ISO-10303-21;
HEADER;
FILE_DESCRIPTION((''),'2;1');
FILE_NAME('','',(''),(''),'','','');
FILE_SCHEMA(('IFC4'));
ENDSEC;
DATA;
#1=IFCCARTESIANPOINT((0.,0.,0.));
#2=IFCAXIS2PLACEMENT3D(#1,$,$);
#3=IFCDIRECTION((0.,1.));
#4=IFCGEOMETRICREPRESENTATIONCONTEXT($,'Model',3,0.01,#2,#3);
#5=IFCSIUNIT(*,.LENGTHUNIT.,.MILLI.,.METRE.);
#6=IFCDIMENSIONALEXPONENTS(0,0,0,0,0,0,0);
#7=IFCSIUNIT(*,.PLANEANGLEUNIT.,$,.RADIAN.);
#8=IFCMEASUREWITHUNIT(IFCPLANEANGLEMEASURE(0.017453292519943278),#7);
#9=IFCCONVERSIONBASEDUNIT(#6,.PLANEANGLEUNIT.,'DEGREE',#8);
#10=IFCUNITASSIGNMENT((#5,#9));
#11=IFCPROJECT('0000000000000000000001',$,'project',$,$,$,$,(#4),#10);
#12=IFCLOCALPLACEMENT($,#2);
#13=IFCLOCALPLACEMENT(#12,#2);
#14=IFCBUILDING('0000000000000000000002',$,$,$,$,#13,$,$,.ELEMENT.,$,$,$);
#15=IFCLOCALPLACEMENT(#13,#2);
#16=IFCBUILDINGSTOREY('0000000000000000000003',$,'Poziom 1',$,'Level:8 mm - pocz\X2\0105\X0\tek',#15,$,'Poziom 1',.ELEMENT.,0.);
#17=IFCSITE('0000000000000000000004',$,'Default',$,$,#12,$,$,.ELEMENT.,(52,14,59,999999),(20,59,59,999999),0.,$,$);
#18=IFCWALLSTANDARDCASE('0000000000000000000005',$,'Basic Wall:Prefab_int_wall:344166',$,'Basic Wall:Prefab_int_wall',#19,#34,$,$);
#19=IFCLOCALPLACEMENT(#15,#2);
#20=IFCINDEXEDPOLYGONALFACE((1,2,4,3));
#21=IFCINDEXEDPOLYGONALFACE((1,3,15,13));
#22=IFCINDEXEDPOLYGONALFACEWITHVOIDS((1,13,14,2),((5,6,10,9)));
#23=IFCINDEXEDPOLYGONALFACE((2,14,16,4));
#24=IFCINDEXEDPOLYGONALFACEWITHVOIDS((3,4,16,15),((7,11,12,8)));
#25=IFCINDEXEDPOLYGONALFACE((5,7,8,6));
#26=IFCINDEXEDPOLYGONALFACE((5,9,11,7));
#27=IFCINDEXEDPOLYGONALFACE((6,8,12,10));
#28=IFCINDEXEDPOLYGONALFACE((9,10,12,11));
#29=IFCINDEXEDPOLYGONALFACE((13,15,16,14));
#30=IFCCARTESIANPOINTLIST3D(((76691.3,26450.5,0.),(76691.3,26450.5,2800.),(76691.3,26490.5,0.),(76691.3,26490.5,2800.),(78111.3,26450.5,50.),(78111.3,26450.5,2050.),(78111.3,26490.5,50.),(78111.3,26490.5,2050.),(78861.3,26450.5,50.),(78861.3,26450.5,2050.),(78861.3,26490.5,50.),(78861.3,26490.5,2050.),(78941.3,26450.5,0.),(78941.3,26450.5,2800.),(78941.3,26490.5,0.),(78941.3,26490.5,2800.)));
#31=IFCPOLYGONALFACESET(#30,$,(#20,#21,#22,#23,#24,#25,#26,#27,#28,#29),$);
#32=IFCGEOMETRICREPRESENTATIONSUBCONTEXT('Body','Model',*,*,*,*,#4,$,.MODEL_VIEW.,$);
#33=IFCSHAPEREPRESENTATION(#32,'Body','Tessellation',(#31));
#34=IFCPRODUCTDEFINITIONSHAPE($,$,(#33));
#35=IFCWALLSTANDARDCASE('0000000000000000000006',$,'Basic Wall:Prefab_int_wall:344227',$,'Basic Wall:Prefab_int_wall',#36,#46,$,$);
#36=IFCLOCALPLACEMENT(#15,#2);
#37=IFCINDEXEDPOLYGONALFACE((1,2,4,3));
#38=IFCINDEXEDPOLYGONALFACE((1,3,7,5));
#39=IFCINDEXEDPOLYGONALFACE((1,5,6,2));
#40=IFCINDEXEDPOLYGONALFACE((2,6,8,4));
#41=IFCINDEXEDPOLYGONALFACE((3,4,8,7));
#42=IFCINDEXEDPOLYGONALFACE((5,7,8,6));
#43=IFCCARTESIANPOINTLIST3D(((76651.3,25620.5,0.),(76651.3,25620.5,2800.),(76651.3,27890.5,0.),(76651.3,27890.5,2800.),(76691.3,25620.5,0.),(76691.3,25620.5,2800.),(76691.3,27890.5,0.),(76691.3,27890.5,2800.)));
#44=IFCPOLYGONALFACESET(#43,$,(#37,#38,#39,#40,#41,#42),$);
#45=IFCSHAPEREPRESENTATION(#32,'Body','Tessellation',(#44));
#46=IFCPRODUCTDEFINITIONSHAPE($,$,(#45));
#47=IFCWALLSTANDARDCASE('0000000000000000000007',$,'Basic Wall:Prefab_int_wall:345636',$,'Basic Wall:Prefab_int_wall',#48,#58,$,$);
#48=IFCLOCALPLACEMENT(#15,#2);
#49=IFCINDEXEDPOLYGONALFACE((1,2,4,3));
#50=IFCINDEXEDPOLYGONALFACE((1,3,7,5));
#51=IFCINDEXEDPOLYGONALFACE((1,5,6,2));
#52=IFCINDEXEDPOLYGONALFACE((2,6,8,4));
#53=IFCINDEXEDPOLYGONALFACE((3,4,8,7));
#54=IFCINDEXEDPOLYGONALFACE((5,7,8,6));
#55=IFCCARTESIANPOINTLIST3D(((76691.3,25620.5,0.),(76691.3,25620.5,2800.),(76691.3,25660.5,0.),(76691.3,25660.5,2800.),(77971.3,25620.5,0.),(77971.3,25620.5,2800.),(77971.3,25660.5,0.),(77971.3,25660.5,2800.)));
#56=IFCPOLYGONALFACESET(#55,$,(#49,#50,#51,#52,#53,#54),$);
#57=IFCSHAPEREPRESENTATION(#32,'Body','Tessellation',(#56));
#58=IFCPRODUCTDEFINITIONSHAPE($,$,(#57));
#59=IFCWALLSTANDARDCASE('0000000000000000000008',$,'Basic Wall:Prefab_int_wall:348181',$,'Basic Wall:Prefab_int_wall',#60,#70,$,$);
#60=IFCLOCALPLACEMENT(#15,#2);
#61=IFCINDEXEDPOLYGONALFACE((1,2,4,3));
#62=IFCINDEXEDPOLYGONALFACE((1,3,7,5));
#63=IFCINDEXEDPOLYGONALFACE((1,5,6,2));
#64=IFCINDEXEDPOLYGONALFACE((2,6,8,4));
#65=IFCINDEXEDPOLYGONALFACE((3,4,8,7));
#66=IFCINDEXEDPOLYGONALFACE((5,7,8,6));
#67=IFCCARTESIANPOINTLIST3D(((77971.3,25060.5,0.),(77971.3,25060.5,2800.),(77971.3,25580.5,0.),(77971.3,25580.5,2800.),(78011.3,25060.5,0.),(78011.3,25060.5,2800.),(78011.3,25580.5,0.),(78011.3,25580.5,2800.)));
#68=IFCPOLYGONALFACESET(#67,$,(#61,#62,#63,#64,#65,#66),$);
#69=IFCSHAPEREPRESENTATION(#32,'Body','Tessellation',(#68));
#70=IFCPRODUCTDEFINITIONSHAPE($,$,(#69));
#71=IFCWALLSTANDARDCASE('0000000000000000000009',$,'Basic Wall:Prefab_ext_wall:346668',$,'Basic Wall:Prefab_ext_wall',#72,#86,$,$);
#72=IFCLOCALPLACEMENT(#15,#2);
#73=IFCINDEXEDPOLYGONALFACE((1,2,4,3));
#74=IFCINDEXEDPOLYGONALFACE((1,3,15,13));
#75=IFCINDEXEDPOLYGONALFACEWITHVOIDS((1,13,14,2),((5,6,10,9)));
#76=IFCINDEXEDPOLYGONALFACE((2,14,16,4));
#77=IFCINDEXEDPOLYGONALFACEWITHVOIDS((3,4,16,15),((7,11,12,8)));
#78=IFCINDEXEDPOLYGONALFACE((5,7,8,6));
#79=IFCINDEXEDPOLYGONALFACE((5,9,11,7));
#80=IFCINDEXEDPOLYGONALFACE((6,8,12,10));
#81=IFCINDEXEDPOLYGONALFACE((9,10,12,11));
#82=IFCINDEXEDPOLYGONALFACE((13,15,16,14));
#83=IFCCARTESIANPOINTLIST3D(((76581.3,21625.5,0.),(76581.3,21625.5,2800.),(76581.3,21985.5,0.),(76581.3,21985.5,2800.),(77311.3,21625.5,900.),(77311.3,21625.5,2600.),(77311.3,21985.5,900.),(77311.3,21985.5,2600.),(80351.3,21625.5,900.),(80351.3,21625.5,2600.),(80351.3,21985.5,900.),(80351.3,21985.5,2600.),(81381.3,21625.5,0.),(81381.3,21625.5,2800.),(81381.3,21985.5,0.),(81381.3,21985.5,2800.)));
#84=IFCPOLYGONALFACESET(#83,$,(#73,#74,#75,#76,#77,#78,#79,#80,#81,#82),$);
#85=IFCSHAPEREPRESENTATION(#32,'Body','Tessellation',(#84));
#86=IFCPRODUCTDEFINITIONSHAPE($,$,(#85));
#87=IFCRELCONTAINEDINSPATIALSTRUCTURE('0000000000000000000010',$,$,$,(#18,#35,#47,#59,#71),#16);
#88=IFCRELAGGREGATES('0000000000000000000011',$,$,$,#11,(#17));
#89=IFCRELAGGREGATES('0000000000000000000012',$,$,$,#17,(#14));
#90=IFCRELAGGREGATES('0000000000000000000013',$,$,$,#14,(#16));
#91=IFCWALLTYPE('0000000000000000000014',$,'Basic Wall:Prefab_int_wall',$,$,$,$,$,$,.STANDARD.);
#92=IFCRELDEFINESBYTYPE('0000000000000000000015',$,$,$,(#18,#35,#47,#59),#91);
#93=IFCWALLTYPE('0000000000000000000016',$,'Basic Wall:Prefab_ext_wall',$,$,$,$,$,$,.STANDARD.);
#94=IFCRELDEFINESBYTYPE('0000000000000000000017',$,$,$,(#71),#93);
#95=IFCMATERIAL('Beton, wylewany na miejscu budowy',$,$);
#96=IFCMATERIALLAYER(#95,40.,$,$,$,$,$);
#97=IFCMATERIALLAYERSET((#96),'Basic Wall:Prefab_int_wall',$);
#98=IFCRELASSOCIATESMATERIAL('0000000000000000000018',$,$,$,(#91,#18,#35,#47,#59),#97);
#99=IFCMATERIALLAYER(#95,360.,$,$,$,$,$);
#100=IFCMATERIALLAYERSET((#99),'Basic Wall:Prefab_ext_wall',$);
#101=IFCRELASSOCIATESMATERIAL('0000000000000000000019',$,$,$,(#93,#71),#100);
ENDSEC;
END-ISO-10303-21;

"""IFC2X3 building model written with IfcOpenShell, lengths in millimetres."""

from ifc_helpers import new_model, entity, si_unit, converted_unit, direction, frame, frame_2d, origin, origin_2d_with_axis, place, context, subcontext, project, spatial, rectangle, extrude, material, layer, layer_set, layer_usage, type_object, element, save


model = new_model("IFC2X3")

# Units and contexts
model_context = context("Model", 3, precision=0.01, world=origin(), true_north=direction((0.0, 1.0)))
body_context = subcontext(model_context, "Body", "Model", "MODEL_VIEW")
ifc_project = project(units=[si_unit("LENGTHUNIT", "METRE", prefix="MILLI"), converted_unit("PLANEANGLEUNIT", "DEGREE", entity("IfcPlaneAngleMeasure", 0.017453292519943278), si_unit("PLANEANGLEUNIT", "RADIAN"), dimensions=[0, 0, 0, 0, 0, 0, 0])], contexts=[model_context])

# Site, building, storey
site_placement = place(None, origin())
site = spatial("IfcSite", under=ifc_project, at=site_placement, Name="Default", CompositionType="ELEMENT", RefLatitude=(52, 14, 59, 999999), RefLongitude=(20, 59, 59, 999999), RefElevation=0.0)
building_placement = place(site_placement, origin())
building = spatial("IfcBuilding", under=site, at=building_placement, CompositionType="ELEMENT")
storey_placement = place(building_placement, origin())
storey = spatial("IfcBuildingStorey", under=building, at=storey_placement, Name="Poziom 1", ObjectType="Level:8 mm - początek", LongName="Poziom 1", CompositionType="ELEMENT", Elevation=0.0)

# Shared definitions
ifc_material_1 = material(Name="Beton, wylewany na miejscu budowy")

# Shared definitions
ifc_layer_1 = layer(ifc_material_1, 40.0)
ifc_layer_set_1 = layer_set([ifc_layer_1], Name="Basic Wall:Prefab_int_wall")
wall_type_1 = type_object("IfcWallType", Name="Basic Wall:Prefab_int_wall", PredefinedType="STANDARD", material=ifc_layer_set_1)

# Wall, opening
ifc_layer_usage_1 = layer_usage(ifc_layer_set_1, "AXIS2", "NEGATIVE", 20.0)
wall_1_placement = place(storey_placement, frame((78941.3, 26470.5, 0.0), z_axis=(0.0, 0.0, 1.0), x_axis=(-1.0, 0.0, 0.0)))
wall_1 = element("IfcWallStandardCase", 1, at=wall_1_placement, inside=storey, type_object=wall_type_1, material=ifc_layer_usage_1, Name="Basic Wall:Prefab_int_wall:344166", ObjectType="Basic Wall:Prefab_int_wall", context=body_context, shape_type="SweptSolid", body=[
    extrude(rectangle(XDim=2250.0, YDim=40.0, at=frame_2d((1125.0, 0.0), x_axis=(-1.0, 0.0))), origin(), (0.0, 0.0, 1.0), 2800.0),
])
opening_1_placement = place(wall_1_placement, origin())
element("IfcOpeningElement", 2, at=opening_1_placement, cuts=wall_1, ObjectType="Opening", context=body_context, shape_type="SweptSolid", body=[
    extrude(rectangle(XDim=2000.0, YDim=750.0, at=origin_2d_with_axis()), frame((455.0, 20.0, 1050.0), z_axis=(0.0, -1.0, 0.0), x_axis=(0.0, 0.0, 1.0)), (0.0, 0.0, 1.0), 40.0),
])

# Walls
ifc_layer_usage_2 = layer_usage(ifc_layer_set_1, "AXIS2", "NEGATIVE", 20.0)
wall_2_placement = place(storey_placement, frame((76671.3, 25620.5, 0.0), z_axis=(0.0, 0.0, 1.0), x_axis=(0.0, 1.0, 0.0)))
element("IfcWallStandardCase", 3, at=wall_2_placement, inside=storey, type_object=wall_type_1, material=ifc_layer_usage_2, Name="Basic Wall:Prefab_int_wall:344227", ObjectType="Basic Wall:Prefab_int_wall", context=body_context, shape_type="SweptSolid", body=[
    extrude(rectangle(XDim=2270.0, YDim=40.0, at=frame_2d((1135.0, 0.0), x_axis=(-1.0, 0.0))), origin(), (0.0, 0.0, 1.0), 2800.0),
])
ifc_layer_usage_3 = layer_usage(ifc_layer_set_1, "AXIS2", "NEGATIVE", 20.0)
wall_3_placement = place(storey_placement, frame((77971.3, 25640.5, 0.0), z_axis=(0.0, 0.0, 1.0), x_axis=(-1.0, 0.0, 0.0)))
element("IfcWallStandardCase", 4, at=wall_3_placement, inside=storey, type_object=wall_type_1, material=ifc_layer_usage_3, Name="Basic Wall:Prefab_int_wall:345636", ObjectType="Basic Wall:Prefab_int_wall", context=body_context, shape_type="SweptSolid", body=[
    extrude(rectangle(XDim=1280.0, YDim=40.0, at=frame_2d((640.0, 0.0), x_axis=(-1.0, 0.0))), origin(), (0.0, 0.0, 1.0), 2800.0),
])
ifc_layer_usage_4 = layer_usage(ifc_layer_set_1, "AXIS2", "NEGATIVE", 20.0)
wall_4_placement = place(storey_placement, frame((77991.3, 25580.5, 0.0), z_axis=(0.0, 0.0, 1.0), x_axis=(0.0, -1.0, 0.0)))
element("IfcWallStandardCase", 5, at=wall_4_placement, inside=storey, type_object=wall_type_1, material=ifc_layer_usage_4, Name="Basic Wall:Prefab_int_wall:348181", ObjectType="Basic Wall:Prefab_int_wall", context=body_context, shape_type="SweptSolid", body=[
    extrude(rectangle(XDim=520.0, YDim=40.0, at=frame_2d((260.0, 0.0), x_axis=(-1.0, 0.0))), origin(), (0.0, 0.0, 1.0), 2800.0),
])

# Wall, opening
ifc_layer_2 = layer(ifc_material_1, 360.0)
ifc_layer_set_2 = layer_set([ifc_layer_2], Name="Basic Wall:Prefab_ext_wall")
wall_type_2 = type_object("IfcWallType", Name="Basic Wall:Prefab_ext_wall", PredefinedType="STANDARD", material=ifc_layer_set_2)
ifc_layer_usage_5 = layer_usage(ifc_layer_set_2, "AXIS2", "NEGATIVE", 180.0)
wall_5_placement = place(storey_placement, frame((76581.3, 21805.5, 0.0)))
wall_5 = element("IfcWallStandardCase", 6, at=wall_5_placement, inside=storey, type_object=wall_type_2, material=ifc_layer_usage_5, Name="Basic Wall:Prefab_ext_wall:346668", ObjectType="Basic Wall:Prefab_ext_wall", context=body_context, shape_type="SweptSolid", body=[
    extrude(rectangle(XDim=4800.0, YDim=360.0, at=frame_2d((2400.0, 0.0), x_axis=(-1.0, 0.0))), origin(), (0.0, 0.0, 1.0), 2800.0),
])
opening_2_placement = place(wall_5_placement, origin())
element("IfcOpeningElement", 7, at=opening_2_placement, cuts=wall_5, ObjectType="Opening", context=body_context, shape_type="SweptSolid", body=[
    extrude(rectangle(XDim=1700.0, YDim=3040.0, at=origin_2d_with_axis()), frame((2250.0, 180.0, 1750.0), z_axis=(0.0, -1.0, 0.0), x_axis=(0.0, 0.0, -1.0)), (0.0, 0.0, 1.0), 360.0),
])

save(model, "model.ifc")
